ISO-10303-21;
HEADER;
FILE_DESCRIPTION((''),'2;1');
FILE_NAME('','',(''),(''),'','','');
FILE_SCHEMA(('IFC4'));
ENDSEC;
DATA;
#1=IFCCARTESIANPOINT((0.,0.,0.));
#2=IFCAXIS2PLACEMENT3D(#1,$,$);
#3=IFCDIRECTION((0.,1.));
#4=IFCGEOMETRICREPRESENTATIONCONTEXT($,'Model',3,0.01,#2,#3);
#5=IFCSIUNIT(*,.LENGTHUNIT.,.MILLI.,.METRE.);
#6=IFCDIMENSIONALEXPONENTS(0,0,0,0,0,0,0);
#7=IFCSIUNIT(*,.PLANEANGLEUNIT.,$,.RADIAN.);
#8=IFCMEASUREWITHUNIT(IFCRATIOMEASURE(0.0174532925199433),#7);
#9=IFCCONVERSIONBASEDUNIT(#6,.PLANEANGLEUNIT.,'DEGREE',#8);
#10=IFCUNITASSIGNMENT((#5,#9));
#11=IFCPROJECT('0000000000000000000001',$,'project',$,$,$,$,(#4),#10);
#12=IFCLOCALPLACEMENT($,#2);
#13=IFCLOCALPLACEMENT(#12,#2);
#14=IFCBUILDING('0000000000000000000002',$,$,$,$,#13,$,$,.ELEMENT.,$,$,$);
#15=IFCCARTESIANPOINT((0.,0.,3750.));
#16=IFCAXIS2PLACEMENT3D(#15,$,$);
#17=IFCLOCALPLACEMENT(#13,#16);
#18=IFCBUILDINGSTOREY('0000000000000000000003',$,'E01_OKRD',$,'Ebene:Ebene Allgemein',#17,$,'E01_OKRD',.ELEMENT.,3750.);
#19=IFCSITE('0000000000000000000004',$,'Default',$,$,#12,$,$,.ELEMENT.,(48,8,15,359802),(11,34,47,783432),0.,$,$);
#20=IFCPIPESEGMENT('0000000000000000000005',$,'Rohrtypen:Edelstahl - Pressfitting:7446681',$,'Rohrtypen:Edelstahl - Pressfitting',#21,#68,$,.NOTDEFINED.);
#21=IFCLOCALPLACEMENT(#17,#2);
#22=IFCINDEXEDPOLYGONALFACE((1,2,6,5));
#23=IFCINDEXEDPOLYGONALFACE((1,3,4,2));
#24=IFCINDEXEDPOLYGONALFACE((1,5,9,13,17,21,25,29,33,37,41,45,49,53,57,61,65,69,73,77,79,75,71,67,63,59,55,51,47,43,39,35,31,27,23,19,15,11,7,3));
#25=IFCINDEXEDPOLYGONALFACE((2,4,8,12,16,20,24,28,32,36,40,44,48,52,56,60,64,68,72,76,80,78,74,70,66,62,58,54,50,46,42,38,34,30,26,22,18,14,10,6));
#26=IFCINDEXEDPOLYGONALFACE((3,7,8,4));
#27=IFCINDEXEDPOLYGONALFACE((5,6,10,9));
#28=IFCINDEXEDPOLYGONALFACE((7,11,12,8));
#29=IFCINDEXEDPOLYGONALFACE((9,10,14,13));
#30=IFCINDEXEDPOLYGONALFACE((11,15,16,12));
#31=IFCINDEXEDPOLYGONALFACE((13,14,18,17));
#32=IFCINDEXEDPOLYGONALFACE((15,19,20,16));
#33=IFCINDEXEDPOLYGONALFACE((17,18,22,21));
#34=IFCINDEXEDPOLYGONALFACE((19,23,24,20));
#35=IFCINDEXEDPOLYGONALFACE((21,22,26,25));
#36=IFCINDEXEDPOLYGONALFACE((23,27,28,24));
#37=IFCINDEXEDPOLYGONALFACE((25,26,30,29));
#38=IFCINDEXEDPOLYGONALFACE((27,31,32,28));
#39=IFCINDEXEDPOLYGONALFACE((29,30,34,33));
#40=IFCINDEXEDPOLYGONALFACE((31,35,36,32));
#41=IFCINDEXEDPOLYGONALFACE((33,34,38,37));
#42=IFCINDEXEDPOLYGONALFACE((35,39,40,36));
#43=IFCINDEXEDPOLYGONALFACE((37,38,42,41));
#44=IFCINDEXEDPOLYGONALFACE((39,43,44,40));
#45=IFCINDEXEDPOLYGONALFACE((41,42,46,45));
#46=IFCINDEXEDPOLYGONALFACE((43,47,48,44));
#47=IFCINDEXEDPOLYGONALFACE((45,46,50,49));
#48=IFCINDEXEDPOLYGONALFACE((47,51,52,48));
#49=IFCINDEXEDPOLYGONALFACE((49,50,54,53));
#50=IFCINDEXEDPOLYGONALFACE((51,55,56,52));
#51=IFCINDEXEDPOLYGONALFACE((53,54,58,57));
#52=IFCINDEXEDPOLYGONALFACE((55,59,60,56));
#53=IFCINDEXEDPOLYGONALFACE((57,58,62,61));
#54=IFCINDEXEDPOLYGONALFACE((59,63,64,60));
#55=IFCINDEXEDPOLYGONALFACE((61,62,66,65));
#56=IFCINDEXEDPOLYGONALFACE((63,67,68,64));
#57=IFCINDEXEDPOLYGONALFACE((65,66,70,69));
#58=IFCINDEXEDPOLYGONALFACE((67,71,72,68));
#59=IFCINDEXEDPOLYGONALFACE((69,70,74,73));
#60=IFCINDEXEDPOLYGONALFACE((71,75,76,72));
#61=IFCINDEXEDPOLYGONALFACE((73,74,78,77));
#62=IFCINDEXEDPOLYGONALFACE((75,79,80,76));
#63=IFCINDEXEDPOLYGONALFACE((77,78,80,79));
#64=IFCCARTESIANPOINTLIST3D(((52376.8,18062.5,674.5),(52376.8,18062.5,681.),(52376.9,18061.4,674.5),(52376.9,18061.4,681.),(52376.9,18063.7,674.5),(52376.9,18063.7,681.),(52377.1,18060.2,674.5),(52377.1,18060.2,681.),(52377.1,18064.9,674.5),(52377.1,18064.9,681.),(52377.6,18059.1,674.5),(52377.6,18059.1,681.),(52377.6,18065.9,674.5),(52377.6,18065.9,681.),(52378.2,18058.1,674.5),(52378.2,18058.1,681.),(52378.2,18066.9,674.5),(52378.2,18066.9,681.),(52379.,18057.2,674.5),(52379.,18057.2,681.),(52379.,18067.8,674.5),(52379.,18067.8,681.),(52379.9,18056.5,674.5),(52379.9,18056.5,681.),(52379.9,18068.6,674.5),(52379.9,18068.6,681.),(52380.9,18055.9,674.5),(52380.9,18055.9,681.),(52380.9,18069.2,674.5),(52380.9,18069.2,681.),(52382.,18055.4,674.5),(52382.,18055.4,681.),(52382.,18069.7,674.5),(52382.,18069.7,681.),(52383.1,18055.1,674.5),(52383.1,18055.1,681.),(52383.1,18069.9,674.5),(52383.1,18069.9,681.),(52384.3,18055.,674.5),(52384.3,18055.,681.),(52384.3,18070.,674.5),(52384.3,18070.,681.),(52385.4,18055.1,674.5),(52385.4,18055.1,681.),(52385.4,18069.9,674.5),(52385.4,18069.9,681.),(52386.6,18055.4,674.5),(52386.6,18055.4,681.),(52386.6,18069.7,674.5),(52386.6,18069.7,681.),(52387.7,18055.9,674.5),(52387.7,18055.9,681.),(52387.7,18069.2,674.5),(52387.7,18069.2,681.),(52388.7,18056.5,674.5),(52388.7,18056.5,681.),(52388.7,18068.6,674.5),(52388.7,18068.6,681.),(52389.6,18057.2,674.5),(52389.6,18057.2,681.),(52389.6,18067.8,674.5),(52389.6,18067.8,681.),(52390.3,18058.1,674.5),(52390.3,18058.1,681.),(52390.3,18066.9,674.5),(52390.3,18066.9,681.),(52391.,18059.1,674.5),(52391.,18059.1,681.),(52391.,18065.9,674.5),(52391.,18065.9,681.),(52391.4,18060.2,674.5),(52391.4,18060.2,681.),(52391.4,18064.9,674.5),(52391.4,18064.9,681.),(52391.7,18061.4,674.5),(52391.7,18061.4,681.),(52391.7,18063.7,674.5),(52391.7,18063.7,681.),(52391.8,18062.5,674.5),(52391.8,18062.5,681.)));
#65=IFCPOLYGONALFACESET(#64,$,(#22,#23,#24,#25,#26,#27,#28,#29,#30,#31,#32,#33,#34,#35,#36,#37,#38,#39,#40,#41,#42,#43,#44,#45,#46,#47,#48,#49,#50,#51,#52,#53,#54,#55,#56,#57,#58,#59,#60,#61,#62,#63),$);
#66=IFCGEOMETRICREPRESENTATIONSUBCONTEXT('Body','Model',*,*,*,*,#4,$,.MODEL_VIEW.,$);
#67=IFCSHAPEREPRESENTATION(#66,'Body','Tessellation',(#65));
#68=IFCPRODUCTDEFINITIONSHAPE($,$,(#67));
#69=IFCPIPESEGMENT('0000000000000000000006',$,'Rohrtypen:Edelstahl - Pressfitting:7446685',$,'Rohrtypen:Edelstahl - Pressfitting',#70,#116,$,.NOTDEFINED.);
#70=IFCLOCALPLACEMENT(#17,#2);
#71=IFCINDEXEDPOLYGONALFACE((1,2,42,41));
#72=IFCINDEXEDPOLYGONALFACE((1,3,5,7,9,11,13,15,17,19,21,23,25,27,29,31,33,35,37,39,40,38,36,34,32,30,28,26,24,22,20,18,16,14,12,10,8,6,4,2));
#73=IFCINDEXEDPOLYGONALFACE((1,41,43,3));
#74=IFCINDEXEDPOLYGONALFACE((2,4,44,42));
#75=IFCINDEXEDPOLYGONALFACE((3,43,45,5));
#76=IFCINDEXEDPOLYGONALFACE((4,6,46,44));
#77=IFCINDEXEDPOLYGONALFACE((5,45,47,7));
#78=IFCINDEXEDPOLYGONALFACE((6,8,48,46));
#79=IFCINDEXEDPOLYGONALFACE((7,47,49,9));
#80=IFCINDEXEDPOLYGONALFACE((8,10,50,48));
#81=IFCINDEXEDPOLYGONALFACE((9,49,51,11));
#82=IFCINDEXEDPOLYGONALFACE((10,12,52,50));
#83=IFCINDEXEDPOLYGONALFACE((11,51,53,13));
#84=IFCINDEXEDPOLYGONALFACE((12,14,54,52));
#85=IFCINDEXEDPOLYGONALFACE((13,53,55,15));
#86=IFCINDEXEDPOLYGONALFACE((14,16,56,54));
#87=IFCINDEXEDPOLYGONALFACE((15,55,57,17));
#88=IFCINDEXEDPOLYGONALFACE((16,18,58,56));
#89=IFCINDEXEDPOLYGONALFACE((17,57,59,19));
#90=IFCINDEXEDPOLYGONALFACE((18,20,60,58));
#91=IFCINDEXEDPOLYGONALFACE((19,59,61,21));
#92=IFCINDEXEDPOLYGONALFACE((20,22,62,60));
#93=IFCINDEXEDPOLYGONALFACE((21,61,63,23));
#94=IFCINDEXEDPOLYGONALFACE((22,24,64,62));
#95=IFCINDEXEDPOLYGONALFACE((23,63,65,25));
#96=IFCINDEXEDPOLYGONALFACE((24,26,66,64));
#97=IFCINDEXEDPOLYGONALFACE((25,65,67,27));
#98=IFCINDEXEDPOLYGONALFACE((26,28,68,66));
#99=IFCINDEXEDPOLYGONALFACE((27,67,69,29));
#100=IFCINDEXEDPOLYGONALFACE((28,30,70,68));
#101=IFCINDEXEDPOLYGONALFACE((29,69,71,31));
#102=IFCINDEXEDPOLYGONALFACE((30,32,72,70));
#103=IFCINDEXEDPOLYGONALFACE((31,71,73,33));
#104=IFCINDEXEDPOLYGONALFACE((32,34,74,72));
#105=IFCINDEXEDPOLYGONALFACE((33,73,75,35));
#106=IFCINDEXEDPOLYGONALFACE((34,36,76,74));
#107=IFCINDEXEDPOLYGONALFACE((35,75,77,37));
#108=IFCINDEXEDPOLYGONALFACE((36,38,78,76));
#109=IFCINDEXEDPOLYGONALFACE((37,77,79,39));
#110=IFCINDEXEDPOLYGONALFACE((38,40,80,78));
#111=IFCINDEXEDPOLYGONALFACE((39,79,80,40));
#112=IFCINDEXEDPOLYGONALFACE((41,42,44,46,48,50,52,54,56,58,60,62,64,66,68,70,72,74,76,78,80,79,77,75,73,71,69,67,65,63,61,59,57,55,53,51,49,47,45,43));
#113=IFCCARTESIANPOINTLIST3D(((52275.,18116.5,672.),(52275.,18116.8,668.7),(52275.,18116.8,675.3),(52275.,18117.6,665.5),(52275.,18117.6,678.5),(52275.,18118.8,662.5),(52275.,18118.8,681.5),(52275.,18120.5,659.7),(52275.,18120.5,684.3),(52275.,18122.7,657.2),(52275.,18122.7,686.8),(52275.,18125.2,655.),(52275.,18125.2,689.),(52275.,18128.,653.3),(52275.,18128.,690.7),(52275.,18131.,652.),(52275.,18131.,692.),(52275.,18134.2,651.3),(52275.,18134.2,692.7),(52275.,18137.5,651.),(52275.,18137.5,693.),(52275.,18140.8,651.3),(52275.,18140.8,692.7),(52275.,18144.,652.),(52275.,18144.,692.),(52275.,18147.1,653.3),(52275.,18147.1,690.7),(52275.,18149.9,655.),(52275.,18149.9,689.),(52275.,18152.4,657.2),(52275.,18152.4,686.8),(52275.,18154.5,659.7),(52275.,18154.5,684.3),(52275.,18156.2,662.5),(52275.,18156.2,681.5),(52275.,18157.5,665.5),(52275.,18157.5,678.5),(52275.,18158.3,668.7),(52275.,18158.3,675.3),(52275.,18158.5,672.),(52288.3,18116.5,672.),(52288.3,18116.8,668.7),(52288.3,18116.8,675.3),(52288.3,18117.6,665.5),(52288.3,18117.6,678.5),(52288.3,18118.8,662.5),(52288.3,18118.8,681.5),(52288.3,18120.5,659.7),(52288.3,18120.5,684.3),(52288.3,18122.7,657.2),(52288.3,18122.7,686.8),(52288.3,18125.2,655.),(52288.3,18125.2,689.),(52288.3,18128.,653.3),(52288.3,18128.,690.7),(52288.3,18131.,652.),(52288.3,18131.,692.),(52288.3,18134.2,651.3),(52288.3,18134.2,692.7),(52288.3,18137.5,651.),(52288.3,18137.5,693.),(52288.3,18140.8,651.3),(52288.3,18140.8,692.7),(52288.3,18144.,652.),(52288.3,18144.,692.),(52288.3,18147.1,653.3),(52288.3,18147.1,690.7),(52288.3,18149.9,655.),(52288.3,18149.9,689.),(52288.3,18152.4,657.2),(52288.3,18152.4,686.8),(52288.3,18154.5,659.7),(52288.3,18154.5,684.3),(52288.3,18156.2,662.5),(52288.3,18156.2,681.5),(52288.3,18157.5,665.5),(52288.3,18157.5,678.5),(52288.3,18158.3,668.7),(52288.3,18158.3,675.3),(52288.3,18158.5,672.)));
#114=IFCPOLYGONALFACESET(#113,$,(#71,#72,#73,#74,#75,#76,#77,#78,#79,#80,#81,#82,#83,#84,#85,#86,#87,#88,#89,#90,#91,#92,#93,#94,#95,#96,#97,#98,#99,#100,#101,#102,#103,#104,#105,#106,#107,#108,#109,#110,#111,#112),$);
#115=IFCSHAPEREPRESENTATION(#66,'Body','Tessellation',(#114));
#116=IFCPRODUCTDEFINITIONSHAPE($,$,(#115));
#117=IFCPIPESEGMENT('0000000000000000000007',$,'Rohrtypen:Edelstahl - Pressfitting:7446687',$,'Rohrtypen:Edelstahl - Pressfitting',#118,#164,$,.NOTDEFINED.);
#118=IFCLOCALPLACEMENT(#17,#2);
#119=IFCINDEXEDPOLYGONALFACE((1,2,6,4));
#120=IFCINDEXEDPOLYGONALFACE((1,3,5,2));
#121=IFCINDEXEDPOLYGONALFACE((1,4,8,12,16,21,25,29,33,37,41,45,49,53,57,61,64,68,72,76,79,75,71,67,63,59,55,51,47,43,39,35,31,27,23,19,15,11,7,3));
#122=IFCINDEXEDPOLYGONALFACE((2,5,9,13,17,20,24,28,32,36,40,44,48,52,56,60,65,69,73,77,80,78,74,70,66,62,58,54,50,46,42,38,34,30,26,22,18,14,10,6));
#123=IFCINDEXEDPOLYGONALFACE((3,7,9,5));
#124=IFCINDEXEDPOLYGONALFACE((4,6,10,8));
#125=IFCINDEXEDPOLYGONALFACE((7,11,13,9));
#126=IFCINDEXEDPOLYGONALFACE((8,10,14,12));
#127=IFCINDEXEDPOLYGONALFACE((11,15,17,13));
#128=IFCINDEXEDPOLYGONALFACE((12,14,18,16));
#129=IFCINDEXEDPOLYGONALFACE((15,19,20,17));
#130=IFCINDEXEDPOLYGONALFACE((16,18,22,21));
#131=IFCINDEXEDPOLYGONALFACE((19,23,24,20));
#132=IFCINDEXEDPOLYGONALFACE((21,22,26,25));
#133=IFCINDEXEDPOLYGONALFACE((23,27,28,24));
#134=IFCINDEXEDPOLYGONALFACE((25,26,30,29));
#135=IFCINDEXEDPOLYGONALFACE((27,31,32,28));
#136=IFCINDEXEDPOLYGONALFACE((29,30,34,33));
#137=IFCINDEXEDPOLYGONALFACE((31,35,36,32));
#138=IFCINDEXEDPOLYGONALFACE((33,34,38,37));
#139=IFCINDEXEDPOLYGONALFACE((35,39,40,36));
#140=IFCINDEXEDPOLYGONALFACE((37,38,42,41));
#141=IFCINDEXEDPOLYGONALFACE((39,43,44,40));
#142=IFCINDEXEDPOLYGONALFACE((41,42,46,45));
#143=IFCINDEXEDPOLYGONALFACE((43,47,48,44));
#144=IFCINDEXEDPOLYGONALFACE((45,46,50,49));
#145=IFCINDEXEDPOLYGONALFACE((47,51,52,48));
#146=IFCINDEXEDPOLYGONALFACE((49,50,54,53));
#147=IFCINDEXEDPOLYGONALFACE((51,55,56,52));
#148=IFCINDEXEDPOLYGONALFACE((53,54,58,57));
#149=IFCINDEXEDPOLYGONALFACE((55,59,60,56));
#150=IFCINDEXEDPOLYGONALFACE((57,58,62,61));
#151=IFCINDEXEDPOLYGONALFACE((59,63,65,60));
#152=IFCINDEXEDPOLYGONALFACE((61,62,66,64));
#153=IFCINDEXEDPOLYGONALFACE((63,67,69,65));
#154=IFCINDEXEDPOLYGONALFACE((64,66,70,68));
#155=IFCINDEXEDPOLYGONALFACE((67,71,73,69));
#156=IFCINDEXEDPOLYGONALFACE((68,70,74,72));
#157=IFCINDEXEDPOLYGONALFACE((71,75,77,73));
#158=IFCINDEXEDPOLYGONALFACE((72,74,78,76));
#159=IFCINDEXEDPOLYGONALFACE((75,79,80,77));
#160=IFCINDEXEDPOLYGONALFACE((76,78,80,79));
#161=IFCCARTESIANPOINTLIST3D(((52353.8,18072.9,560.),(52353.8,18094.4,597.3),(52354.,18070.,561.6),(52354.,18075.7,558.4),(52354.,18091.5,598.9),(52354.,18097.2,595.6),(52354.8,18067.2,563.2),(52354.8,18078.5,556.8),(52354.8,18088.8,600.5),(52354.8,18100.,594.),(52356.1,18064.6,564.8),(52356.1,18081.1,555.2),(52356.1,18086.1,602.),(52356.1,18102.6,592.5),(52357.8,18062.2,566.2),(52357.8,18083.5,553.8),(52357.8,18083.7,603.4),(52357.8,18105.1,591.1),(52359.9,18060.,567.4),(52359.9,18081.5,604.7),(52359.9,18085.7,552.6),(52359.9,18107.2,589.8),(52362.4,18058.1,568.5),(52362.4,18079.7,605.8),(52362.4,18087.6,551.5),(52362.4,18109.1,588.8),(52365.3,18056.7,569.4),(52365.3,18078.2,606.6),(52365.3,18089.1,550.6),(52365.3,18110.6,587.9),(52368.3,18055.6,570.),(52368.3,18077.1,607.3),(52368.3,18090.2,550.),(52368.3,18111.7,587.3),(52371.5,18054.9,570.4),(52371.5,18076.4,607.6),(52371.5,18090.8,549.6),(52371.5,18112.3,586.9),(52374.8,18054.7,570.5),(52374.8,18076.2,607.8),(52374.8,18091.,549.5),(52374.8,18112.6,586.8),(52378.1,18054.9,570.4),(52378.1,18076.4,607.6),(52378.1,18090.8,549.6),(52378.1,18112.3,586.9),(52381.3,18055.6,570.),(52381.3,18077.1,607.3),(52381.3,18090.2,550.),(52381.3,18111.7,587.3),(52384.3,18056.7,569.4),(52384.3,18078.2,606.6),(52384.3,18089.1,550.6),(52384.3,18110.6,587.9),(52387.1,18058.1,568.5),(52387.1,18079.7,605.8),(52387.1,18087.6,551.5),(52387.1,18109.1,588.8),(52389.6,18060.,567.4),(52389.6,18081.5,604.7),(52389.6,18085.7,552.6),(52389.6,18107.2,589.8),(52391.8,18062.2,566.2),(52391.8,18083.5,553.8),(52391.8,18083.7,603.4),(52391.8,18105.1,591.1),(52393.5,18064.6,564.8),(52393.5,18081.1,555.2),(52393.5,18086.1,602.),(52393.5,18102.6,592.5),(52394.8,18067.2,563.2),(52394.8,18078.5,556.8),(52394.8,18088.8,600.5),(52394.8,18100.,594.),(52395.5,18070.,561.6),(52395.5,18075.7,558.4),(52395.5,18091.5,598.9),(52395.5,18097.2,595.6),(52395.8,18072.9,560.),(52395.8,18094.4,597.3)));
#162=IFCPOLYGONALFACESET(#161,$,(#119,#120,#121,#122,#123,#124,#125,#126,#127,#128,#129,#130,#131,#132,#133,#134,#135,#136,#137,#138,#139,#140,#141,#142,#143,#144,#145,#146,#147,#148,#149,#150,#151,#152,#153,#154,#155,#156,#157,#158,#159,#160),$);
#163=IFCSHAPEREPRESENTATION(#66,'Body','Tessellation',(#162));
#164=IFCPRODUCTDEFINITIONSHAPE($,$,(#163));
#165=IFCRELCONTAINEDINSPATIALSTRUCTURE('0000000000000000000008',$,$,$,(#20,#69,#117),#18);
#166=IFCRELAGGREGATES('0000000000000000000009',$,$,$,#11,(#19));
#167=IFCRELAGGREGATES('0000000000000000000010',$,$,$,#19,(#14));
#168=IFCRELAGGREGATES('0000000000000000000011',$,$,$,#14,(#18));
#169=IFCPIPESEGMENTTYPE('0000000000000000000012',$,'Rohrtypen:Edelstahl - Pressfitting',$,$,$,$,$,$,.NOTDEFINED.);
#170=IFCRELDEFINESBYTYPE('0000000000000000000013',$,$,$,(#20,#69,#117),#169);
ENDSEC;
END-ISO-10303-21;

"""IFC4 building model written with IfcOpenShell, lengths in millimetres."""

from ifc_helpers import new_model, entity, si_unit, converted_unit, direction, frame, origin, place, context, subcontext, project, spatial, indexed_curve, outline, extrude, type_object, element, save


model = new_model("IFC4")

# Units and contexts
model_context = context("Model", 3, precision=0.01, world=origin(), true_north=direction((0.0, 1.0)))
body_context = subcontext(model_context, "Body", "Model", "MODEL_VIEW")
ifc_project = project(units=[si_unit("LENGTHUNIT", "METRE", prefix="MILLI"), converted_unit("PLANEANGLEUNIT", "DEGREE", entity("IfcRatioMeasure", 0.0174532925199433), si_unit("PLANEANGLEUNIT", "RADIAN"), dimensions=[0, 0, 0, 0, 0, 0, 0])], contexts=[model_context])

# Site, building, storey
site_placement = place(None, origin())
site = spatial("IfcSite", under=ifc_project, at=site_placement, Name="Default", CompositionType="ELEMENT", RefLatitude=(48, 8, 15, 359802), RefLongitude=(11, 34, 47, 783432), RefElevation=0.0)
building_placement = place(site_placement, origin())
building = spatial("IfcBuilding", under=site, at=building_placement, CompositionType="ELEMENT")
storey_placement = place(building_placement, frame((0.0, 0.0, 3750.0)))
storey = spatial("IfcBuildingStorey", under=building, at=storey_placement, Name="E01_OKRD", ObjectType="Ebene:Ebene Allgemein", LongName="E01_OKRD", CompositionType="ELEMENT", Elevation=3750.0)

# Pipe segments
pipe_segment_type_1 = type_object("IfcPipeSegmentType", Name="Rohrtypen:Edelstahl - Pressfitting", PredefinedType="NOTDEFINED")
pipe_segment_1_placement = place(storey_placement, origin())
element("IfcPipeSegment", 1, at=pipe_segment_1_placement, inside=storey, type_object=pipe_segment_type_1, Name="Rohrtypen:Edelstahl - Pressfitting:7446681", ObjectType="Rohrtypen:Edelstahl - Pressfitting", PredefinedType="NOTDEFINED", context=body_context, shape_type="SweptSolid", body=[
    extrude(outline(indexed_curve([(7.5, 0.0), (7.4, 1.2), (7.1, 2.3), (6.7, 3.4), (6.1, 4.4), (5.3, 5.3), (4.4, 6.1), (3.4, 6.7), (2.3, 7.1), (1.2, 7.4), (0.0, 7.5), (-1.2, 7.4), (-2.3, 7.1), (-3.4, 6.7), (-4.4, 6.1), (-5.3, 5.3), (-6.1, 4.4), (-6.7, 3.4), (-7.1, 2.3), (-7.4, 1.2), (-7.5, 0.0), (-7.4, -1.2), (-7.1, -2.3), (-6.7, -3.4), (-6.1, -4.4), (-5.3, -5.3), (-4.4, -6.1), (-3.4, -6.7), (-2.3, -7.1), (-1.2, -7.4), (0.0, -7.5), (1.2, -7.4), (2.3, -7.1), (3.4, -6.7), (4.4, -6.1), (5.3, -5.3), (6.1, -4.4), (6.7, -3.4), (7.1, -2.3), (7.4, -1.2), (7.5, 0.0)], self_intersect=False)), frame((52384.3, 18062.5, 674.5)), (0.0, 0.0, 1.0), 6.5),
])
pipe_segment_2_placement = place(storey_placement, origin())
element("IfcPipeSegment", 2, at=pipe_segment_2_placement, inside=storey, type_object=pipe_segment_type_1, Name="Rohrtypen:Edelstahl - Pressfitting:7446685", ObjectType="Rohrtypen:Edelstahl - Pressfitting", PredefinedType="NOTDEFINED", context=body_context, shape_type="SweptSolid", body=[
    extrude(outline(indexed_curve([(21.0, 0.0), (20.7, 3.3), (20.0, 6.5), (18.7, 9.5), (17.0, 12.3), (14.8, 14.8), (12.3, 17.0), (9.5, 18.7), (6.5, 20.0), (3.3, 20.7), (0.0, 21.0), (-3.3, 20.7), (-6.5, 20.0), (-9.5, 18.7), (-12.3, 17.0), (-14.8, 14.8), (-17.0, 12.3), (-18.7, 9.5), (-20.0, 6.5), (-20.7, 3.3), (-21.0, 0.0), (-20.7, -3.3), (-20.0, -6.5), (-18.7, -9.5), (-17.0, -12.3), (-14.8, -14.8), (-12.3, -17.0), (-9.5, -18.7), (-6.5, -20.0), (-3.3, -20.7), (0.0, -21.0), (3.3, -20.7), (6.5, -20.0), (9.5, -18.7), (12.3, -17.0), (14.8, -14.8), (17.0, -12.3), (18.7, -9.5), (20.0, -6.5), (20.7, -3.3), (21.0, 0.0)], self_intersect=False)), frame((52275.0, 18137.5, 672.0), z_axis=(1.0, 0.0, 0.0), x_axis=(0.0, -1.0, 0.0)), (0.0, 0.0, 1.0), 13.3),
])
pipe_segment_3_placement = place(storey_placement, origin())
element("IfcPipeSegment", 3, at=pipe_segment_3_placement, inside=storey, type_object=pipe_segment_type_1, Name="Rohrtypen:Edelstahl - Pressfitting:7446687", ObjectType="Rohrtypen:Edelstahl - Pressfitting", PredefinedType="NOTDEFINED", context=body_context, shape_type="SweptSolid", body=[
    extrude(outline(indexed_curve([(21.0, 0.0), (20.7, 3.3), (20.0, 6.5), (18.7, 9.5), (17.0, 12.3), (14.8, 14.8), (12.3, 17.0), (9.5, 18.7), (6.5, 20.0), (3.3, 20.7), (0.0, 21.0), (-3.3, 20.7), (-6.5, 20.0), (-9.5, 18.7), (-12.3, 17.0), (-14.8, 14.8), (-17.0, 12.3), (-18.7, 9.5), (-20.0, 6.5), (-20.7, 3.3), (-21.0, 0.0), (-20.7, -3.3), (-20.0, -6.5), (-18.7, -9.5), (-17.0, -12.3), (-14.8, -14.8), (-12.3, -17.0), (-9.5, -18.7), (-6.5, -20.0), (-3.3, -20.7), (0.0, -21.0), (3.3, -20.7), (6.5, -20.0), (9.5, -18.7), (12.3, -17.0), (14.8, -14.8), (17.0, -12.3), (18.7, -9.5), (20.0, -6.5), (20.7, -3.3), (21.0, 0.0)], self_intersect=False)), frame((52374.8, 18072.9, 560.0), z_axis=(0.0, 0.5, 0.866025), x_axis=(-1.0, 0.0, 0.0)), (0.0, 0.0, 1.0), 43.0),
])

save(model, "model.ifc")
